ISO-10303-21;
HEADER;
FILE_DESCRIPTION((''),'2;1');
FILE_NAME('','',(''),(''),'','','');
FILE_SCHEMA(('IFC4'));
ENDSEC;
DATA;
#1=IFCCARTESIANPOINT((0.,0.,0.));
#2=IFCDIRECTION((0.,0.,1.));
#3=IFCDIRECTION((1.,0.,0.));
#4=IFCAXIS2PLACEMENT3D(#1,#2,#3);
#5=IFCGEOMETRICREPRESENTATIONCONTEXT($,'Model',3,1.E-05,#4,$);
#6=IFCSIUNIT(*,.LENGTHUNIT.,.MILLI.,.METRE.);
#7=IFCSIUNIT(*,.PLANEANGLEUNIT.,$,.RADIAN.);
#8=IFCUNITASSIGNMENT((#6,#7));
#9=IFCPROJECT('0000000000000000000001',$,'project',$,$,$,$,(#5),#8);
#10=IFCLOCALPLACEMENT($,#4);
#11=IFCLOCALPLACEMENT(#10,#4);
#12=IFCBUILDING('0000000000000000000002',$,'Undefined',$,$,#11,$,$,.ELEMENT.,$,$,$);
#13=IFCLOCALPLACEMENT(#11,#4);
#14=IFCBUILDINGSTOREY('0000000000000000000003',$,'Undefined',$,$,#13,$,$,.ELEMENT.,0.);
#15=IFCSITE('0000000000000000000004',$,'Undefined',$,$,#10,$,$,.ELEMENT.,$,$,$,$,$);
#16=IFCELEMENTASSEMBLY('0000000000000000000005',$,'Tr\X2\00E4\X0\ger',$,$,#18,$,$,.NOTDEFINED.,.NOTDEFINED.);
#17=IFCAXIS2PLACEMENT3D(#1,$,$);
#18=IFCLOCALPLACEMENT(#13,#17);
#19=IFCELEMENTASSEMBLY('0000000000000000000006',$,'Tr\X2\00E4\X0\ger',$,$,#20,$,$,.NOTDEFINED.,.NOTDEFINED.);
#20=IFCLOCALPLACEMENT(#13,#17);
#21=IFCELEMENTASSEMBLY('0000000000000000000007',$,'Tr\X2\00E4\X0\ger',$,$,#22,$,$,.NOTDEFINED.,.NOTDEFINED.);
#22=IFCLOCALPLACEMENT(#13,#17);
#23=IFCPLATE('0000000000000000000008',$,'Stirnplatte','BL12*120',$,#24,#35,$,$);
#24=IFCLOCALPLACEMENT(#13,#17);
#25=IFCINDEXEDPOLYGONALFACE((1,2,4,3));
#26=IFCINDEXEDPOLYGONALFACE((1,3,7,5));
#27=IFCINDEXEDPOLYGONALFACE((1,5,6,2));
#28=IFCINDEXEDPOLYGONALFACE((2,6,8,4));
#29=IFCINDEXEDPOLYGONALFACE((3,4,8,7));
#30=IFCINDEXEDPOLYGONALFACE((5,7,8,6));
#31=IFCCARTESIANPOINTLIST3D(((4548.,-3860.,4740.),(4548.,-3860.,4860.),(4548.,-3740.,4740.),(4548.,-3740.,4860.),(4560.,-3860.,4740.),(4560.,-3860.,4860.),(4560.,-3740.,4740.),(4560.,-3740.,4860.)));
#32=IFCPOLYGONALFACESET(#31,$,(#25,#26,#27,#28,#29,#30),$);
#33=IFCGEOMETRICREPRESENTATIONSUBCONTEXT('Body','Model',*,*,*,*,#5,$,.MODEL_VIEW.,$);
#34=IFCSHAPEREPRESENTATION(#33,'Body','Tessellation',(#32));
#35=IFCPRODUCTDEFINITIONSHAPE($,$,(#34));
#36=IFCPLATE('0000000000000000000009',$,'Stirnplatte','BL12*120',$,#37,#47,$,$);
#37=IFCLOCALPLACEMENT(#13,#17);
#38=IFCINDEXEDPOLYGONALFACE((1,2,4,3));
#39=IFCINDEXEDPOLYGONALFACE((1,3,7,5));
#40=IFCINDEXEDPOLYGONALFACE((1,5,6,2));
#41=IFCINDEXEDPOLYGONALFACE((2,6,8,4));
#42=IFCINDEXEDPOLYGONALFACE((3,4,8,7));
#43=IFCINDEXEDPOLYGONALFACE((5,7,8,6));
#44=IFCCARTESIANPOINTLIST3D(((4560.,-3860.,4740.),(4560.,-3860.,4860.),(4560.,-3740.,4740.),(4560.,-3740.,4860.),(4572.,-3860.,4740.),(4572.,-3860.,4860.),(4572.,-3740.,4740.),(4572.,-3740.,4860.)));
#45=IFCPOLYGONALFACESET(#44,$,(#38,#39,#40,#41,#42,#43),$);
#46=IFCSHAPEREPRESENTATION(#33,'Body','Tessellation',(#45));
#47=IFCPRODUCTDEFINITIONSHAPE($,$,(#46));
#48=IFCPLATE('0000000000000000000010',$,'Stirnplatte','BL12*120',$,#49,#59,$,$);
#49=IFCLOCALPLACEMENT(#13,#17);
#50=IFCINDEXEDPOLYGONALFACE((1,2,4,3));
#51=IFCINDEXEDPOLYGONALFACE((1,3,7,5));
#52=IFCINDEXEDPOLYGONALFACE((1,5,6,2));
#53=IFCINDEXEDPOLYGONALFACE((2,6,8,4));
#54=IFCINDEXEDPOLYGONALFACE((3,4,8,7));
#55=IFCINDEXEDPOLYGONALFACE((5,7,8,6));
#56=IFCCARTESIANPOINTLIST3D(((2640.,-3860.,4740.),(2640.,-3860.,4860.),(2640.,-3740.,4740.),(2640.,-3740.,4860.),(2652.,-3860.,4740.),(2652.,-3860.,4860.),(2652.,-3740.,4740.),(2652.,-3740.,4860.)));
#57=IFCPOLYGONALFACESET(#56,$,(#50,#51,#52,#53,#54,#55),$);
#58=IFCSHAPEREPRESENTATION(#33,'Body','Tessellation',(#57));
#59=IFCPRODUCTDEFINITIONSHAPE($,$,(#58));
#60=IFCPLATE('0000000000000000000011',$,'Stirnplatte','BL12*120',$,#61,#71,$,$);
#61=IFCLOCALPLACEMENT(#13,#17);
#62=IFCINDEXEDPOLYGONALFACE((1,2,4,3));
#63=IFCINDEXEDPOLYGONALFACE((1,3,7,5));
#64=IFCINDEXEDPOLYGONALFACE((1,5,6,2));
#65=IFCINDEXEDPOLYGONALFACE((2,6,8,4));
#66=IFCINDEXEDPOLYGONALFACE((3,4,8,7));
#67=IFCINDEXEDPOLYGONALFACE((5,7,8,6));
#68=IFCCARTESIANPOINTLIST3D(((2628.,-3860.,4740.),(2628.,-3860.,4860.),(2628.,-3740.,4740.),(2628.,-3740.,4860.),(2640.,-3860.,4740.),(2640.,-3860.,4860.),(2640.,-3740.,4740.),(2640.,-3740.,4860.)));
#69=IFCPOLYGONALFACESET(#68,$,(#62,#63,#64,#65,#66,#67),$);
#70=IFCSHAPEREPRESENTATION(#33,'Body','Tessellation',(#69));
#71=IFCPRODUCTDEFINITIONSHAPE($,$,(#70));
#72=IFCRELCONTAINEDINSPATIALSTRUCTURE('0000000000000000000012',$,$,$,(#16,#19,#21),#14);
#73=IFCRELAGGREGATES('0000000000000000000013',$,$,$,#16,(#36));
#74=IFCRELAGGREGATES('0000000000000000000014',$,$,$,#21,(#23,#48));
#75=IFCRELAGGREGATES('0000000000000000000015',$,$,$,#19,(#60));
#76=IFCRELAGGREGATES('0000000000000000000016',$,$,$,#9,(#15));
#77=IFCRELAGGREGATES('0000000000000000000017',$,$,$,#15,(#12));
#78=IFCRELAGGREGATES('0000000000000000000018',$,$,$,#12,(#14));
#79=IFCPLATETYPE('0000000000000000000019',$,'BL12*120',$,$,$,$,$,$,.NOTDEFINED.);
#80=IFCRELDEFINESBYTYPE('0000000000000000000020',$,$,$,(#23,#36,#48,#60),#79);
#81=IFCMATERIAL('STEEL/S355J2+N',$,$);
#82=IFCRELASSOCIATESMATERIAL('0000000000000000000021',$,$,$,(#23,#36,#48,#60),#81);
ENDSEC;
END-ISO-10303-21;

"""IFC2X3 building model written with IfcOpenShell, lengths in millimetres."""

from ifc_helpers import new_model, si_unit, frame, origin_with_axes, place, context, subcontext, project, spatial, polyline, outline, extrude, material, type_object, element, aggregate, save


model = new_model("IFC2X3")

# Units and contexts
model_context = context("Model", 3, precision=1e-05, world=origin_with_axes())
body_context = subcontext(model_context, "Body", "Model", "MODEL_VIEW")
ifc_project = project(units=[si_unit("LENGTHUNIT", "METRE", prefix="MILLI"), si_unit("PLANEANGLEUNIT", "RADIAN")], contexts=[model_context])

# Site, building, storey
site_placement = place(None, origin_with_axes())
site = spatial("IfcSite", under=ifc_project, at=site_placement, Name="Undefined", CompositionType="ELEMENT")
building_placement = place(site_placement, origin_with_axes())
building = spatial("IfcBuilding", under=site, at=building_placement, Name="Undefined", CompositionType="ELEMENT")
storey_placement = place(building_placement, origin_with_axes())
storey = spatial("IfcBuildingStorey", under=building, at=storey_placement, Name="Undefined", CompositionType="ELEMENT", Elevation=0.0)

# Element assemblies
assembly_1_placement = place(storey_placement, origin_with_axes())
assembly_1 = element("IfcElementAssembly", 1, at=assembly_1_placement, inside=storey, Name="Träger", AssemblyPlace="NOTDEFINED", PredefinedType="NOTDEFINED")
assembly_2_placement = place(storey_placement, origin_with_axes())
assembly_2 = element("IfcElementAssembly", 2, at=assembly_2_placement, inside=storey, Name="Träger", AssemblyPlace="NOTDEFINED", PredefinedType="NOTDEFINED")
assembly_3_placement = place(storey_placement, origin_with_axes())
assembly_3 = element("IfcElementAssembly", 3, at=assembly_3_placement, inside=storey, Name="Träger", AssemblyPlace="NOTDEFINED", PredefinedType="NOTDEFINED")

# Shared definitions
ifc_material_1 = material(Name="STEEL/S355J2+N")
plate_type_1 = type_object("IfcPlateType", Name="BL12*120", PredefinedType="NOTDEFINED")

# Plates
plate_1_placement = place(assembly_3_placement, frame((4554.0, -3800.0, 4740.0), z_axis=(-1.0, 0.0, 0.0), x_axis=(0.0, 0.0, 1.0)))
plate_1 = element("IfcPlate", 4, at=plate_1_placement, type_object=plate_type_1, material=ifc_material_1, Name="Stirnplatte", Description="BL12*120", context=body_context, shape_type="SweptSolid", body=[
    extrude(outline(polyline([(0.0, -60.0), (0.0, 60.0), (120.0, 60.0), (120.0, -60.0), (0.0, -60.0)])), frame((0.0, 0.0, -6.0), z_axis=(0.0, 0.0, 1.0), x_axis=(1.0, 0.0, 0.0)), (0.0, 0.0, 1.0), 12.0),
])
plate_2_placement = place(assembly_1_placement, frame((4566.0, -3800.0, 4740.0), z_axis=(-1.0, 0.0, 0.0), x_axis=(0.0, 0.0, 1.0)))
plate_2 = element("IfcPlate", 5, at=plate_2_placement, type_object=plate_type_1, material=ifc_material_1, Name="Stirnplatte", Description="BL12*120", context=body_context, shape_type="SweptSolid", body=[
    extrude(outline(polyline([(0.0, -60.0), (0.0, 60.0), (120.0, 60.0), (120.0, -60.0), (0.0, -60.0)])), frame((0.0, 0.0, -6.0), z_axis=(0.0, 0.0, 1.0), x_axis=(1.0, 0.0, 0.0)), (0.0, 0.0, 1.0), 12.0),
])
aggregate(assembly_1, [plate_2])
plate_3_placement = place(assembly_3_placement, frame((2646.0, -3800.0, 4740.0), z_axis=(1.0, 0.0, 0.0), x_axis=(0.0, 0.0, 1.0)))
plate_3 = element("IfcPlate", 6, at=plate_3_placement, type_object=plate_type_1, material=ifc_material_1, Name="Stirnplatte", Description="BL12*120", context=body_context, shape_type="SweptSolid", body=[
    extrude(outline(polyline([(0.0, -60.0), (0.0, 60.0), (120.0, 60.0), (120.0, -60.0), (0.0, -60.0)])), frame((0.0, 0.0, -6.0), z_axis=(0.0, 0.0, 1.0), x_axis=(1.0, 0.0, 0.0)), (0.0, 0.0, 1.0), 12.0),
])
aggregate(assembly_3, [plate_1, plate_3])
plate_4_placement = place(assembly_2_placement, frame((2634.0, -3800.0, 4740.0), z_axis=(1.0, 0.0, 0.0), x_axis=(0.0, 0.0, 1.0)))
plate_4 = element("IfcPlate", 7, at=plate_4_placement, type_object=plate_type_1, material=ifc_material_1, Name="Stirnplatte", Description="BL12*120", context=body_context, shape_type="SweptSolid", body=[
    extrude(outline(polyline([(0.0, -60.0), (0.0, 60.0), (120.0, 60.0), (120.0, -60.0), (0.0, -60.0)])), frame((0.0, 0.0, -6.0), z_axis=(0.0, 0.0, 1.0), x_axis=(1.0, 0.0, 0.0)), (0.0, 0.0, 1.0), 12.0),
])
aggregate(assembly_2, [plate_4])

save(model, "model.ifc")
